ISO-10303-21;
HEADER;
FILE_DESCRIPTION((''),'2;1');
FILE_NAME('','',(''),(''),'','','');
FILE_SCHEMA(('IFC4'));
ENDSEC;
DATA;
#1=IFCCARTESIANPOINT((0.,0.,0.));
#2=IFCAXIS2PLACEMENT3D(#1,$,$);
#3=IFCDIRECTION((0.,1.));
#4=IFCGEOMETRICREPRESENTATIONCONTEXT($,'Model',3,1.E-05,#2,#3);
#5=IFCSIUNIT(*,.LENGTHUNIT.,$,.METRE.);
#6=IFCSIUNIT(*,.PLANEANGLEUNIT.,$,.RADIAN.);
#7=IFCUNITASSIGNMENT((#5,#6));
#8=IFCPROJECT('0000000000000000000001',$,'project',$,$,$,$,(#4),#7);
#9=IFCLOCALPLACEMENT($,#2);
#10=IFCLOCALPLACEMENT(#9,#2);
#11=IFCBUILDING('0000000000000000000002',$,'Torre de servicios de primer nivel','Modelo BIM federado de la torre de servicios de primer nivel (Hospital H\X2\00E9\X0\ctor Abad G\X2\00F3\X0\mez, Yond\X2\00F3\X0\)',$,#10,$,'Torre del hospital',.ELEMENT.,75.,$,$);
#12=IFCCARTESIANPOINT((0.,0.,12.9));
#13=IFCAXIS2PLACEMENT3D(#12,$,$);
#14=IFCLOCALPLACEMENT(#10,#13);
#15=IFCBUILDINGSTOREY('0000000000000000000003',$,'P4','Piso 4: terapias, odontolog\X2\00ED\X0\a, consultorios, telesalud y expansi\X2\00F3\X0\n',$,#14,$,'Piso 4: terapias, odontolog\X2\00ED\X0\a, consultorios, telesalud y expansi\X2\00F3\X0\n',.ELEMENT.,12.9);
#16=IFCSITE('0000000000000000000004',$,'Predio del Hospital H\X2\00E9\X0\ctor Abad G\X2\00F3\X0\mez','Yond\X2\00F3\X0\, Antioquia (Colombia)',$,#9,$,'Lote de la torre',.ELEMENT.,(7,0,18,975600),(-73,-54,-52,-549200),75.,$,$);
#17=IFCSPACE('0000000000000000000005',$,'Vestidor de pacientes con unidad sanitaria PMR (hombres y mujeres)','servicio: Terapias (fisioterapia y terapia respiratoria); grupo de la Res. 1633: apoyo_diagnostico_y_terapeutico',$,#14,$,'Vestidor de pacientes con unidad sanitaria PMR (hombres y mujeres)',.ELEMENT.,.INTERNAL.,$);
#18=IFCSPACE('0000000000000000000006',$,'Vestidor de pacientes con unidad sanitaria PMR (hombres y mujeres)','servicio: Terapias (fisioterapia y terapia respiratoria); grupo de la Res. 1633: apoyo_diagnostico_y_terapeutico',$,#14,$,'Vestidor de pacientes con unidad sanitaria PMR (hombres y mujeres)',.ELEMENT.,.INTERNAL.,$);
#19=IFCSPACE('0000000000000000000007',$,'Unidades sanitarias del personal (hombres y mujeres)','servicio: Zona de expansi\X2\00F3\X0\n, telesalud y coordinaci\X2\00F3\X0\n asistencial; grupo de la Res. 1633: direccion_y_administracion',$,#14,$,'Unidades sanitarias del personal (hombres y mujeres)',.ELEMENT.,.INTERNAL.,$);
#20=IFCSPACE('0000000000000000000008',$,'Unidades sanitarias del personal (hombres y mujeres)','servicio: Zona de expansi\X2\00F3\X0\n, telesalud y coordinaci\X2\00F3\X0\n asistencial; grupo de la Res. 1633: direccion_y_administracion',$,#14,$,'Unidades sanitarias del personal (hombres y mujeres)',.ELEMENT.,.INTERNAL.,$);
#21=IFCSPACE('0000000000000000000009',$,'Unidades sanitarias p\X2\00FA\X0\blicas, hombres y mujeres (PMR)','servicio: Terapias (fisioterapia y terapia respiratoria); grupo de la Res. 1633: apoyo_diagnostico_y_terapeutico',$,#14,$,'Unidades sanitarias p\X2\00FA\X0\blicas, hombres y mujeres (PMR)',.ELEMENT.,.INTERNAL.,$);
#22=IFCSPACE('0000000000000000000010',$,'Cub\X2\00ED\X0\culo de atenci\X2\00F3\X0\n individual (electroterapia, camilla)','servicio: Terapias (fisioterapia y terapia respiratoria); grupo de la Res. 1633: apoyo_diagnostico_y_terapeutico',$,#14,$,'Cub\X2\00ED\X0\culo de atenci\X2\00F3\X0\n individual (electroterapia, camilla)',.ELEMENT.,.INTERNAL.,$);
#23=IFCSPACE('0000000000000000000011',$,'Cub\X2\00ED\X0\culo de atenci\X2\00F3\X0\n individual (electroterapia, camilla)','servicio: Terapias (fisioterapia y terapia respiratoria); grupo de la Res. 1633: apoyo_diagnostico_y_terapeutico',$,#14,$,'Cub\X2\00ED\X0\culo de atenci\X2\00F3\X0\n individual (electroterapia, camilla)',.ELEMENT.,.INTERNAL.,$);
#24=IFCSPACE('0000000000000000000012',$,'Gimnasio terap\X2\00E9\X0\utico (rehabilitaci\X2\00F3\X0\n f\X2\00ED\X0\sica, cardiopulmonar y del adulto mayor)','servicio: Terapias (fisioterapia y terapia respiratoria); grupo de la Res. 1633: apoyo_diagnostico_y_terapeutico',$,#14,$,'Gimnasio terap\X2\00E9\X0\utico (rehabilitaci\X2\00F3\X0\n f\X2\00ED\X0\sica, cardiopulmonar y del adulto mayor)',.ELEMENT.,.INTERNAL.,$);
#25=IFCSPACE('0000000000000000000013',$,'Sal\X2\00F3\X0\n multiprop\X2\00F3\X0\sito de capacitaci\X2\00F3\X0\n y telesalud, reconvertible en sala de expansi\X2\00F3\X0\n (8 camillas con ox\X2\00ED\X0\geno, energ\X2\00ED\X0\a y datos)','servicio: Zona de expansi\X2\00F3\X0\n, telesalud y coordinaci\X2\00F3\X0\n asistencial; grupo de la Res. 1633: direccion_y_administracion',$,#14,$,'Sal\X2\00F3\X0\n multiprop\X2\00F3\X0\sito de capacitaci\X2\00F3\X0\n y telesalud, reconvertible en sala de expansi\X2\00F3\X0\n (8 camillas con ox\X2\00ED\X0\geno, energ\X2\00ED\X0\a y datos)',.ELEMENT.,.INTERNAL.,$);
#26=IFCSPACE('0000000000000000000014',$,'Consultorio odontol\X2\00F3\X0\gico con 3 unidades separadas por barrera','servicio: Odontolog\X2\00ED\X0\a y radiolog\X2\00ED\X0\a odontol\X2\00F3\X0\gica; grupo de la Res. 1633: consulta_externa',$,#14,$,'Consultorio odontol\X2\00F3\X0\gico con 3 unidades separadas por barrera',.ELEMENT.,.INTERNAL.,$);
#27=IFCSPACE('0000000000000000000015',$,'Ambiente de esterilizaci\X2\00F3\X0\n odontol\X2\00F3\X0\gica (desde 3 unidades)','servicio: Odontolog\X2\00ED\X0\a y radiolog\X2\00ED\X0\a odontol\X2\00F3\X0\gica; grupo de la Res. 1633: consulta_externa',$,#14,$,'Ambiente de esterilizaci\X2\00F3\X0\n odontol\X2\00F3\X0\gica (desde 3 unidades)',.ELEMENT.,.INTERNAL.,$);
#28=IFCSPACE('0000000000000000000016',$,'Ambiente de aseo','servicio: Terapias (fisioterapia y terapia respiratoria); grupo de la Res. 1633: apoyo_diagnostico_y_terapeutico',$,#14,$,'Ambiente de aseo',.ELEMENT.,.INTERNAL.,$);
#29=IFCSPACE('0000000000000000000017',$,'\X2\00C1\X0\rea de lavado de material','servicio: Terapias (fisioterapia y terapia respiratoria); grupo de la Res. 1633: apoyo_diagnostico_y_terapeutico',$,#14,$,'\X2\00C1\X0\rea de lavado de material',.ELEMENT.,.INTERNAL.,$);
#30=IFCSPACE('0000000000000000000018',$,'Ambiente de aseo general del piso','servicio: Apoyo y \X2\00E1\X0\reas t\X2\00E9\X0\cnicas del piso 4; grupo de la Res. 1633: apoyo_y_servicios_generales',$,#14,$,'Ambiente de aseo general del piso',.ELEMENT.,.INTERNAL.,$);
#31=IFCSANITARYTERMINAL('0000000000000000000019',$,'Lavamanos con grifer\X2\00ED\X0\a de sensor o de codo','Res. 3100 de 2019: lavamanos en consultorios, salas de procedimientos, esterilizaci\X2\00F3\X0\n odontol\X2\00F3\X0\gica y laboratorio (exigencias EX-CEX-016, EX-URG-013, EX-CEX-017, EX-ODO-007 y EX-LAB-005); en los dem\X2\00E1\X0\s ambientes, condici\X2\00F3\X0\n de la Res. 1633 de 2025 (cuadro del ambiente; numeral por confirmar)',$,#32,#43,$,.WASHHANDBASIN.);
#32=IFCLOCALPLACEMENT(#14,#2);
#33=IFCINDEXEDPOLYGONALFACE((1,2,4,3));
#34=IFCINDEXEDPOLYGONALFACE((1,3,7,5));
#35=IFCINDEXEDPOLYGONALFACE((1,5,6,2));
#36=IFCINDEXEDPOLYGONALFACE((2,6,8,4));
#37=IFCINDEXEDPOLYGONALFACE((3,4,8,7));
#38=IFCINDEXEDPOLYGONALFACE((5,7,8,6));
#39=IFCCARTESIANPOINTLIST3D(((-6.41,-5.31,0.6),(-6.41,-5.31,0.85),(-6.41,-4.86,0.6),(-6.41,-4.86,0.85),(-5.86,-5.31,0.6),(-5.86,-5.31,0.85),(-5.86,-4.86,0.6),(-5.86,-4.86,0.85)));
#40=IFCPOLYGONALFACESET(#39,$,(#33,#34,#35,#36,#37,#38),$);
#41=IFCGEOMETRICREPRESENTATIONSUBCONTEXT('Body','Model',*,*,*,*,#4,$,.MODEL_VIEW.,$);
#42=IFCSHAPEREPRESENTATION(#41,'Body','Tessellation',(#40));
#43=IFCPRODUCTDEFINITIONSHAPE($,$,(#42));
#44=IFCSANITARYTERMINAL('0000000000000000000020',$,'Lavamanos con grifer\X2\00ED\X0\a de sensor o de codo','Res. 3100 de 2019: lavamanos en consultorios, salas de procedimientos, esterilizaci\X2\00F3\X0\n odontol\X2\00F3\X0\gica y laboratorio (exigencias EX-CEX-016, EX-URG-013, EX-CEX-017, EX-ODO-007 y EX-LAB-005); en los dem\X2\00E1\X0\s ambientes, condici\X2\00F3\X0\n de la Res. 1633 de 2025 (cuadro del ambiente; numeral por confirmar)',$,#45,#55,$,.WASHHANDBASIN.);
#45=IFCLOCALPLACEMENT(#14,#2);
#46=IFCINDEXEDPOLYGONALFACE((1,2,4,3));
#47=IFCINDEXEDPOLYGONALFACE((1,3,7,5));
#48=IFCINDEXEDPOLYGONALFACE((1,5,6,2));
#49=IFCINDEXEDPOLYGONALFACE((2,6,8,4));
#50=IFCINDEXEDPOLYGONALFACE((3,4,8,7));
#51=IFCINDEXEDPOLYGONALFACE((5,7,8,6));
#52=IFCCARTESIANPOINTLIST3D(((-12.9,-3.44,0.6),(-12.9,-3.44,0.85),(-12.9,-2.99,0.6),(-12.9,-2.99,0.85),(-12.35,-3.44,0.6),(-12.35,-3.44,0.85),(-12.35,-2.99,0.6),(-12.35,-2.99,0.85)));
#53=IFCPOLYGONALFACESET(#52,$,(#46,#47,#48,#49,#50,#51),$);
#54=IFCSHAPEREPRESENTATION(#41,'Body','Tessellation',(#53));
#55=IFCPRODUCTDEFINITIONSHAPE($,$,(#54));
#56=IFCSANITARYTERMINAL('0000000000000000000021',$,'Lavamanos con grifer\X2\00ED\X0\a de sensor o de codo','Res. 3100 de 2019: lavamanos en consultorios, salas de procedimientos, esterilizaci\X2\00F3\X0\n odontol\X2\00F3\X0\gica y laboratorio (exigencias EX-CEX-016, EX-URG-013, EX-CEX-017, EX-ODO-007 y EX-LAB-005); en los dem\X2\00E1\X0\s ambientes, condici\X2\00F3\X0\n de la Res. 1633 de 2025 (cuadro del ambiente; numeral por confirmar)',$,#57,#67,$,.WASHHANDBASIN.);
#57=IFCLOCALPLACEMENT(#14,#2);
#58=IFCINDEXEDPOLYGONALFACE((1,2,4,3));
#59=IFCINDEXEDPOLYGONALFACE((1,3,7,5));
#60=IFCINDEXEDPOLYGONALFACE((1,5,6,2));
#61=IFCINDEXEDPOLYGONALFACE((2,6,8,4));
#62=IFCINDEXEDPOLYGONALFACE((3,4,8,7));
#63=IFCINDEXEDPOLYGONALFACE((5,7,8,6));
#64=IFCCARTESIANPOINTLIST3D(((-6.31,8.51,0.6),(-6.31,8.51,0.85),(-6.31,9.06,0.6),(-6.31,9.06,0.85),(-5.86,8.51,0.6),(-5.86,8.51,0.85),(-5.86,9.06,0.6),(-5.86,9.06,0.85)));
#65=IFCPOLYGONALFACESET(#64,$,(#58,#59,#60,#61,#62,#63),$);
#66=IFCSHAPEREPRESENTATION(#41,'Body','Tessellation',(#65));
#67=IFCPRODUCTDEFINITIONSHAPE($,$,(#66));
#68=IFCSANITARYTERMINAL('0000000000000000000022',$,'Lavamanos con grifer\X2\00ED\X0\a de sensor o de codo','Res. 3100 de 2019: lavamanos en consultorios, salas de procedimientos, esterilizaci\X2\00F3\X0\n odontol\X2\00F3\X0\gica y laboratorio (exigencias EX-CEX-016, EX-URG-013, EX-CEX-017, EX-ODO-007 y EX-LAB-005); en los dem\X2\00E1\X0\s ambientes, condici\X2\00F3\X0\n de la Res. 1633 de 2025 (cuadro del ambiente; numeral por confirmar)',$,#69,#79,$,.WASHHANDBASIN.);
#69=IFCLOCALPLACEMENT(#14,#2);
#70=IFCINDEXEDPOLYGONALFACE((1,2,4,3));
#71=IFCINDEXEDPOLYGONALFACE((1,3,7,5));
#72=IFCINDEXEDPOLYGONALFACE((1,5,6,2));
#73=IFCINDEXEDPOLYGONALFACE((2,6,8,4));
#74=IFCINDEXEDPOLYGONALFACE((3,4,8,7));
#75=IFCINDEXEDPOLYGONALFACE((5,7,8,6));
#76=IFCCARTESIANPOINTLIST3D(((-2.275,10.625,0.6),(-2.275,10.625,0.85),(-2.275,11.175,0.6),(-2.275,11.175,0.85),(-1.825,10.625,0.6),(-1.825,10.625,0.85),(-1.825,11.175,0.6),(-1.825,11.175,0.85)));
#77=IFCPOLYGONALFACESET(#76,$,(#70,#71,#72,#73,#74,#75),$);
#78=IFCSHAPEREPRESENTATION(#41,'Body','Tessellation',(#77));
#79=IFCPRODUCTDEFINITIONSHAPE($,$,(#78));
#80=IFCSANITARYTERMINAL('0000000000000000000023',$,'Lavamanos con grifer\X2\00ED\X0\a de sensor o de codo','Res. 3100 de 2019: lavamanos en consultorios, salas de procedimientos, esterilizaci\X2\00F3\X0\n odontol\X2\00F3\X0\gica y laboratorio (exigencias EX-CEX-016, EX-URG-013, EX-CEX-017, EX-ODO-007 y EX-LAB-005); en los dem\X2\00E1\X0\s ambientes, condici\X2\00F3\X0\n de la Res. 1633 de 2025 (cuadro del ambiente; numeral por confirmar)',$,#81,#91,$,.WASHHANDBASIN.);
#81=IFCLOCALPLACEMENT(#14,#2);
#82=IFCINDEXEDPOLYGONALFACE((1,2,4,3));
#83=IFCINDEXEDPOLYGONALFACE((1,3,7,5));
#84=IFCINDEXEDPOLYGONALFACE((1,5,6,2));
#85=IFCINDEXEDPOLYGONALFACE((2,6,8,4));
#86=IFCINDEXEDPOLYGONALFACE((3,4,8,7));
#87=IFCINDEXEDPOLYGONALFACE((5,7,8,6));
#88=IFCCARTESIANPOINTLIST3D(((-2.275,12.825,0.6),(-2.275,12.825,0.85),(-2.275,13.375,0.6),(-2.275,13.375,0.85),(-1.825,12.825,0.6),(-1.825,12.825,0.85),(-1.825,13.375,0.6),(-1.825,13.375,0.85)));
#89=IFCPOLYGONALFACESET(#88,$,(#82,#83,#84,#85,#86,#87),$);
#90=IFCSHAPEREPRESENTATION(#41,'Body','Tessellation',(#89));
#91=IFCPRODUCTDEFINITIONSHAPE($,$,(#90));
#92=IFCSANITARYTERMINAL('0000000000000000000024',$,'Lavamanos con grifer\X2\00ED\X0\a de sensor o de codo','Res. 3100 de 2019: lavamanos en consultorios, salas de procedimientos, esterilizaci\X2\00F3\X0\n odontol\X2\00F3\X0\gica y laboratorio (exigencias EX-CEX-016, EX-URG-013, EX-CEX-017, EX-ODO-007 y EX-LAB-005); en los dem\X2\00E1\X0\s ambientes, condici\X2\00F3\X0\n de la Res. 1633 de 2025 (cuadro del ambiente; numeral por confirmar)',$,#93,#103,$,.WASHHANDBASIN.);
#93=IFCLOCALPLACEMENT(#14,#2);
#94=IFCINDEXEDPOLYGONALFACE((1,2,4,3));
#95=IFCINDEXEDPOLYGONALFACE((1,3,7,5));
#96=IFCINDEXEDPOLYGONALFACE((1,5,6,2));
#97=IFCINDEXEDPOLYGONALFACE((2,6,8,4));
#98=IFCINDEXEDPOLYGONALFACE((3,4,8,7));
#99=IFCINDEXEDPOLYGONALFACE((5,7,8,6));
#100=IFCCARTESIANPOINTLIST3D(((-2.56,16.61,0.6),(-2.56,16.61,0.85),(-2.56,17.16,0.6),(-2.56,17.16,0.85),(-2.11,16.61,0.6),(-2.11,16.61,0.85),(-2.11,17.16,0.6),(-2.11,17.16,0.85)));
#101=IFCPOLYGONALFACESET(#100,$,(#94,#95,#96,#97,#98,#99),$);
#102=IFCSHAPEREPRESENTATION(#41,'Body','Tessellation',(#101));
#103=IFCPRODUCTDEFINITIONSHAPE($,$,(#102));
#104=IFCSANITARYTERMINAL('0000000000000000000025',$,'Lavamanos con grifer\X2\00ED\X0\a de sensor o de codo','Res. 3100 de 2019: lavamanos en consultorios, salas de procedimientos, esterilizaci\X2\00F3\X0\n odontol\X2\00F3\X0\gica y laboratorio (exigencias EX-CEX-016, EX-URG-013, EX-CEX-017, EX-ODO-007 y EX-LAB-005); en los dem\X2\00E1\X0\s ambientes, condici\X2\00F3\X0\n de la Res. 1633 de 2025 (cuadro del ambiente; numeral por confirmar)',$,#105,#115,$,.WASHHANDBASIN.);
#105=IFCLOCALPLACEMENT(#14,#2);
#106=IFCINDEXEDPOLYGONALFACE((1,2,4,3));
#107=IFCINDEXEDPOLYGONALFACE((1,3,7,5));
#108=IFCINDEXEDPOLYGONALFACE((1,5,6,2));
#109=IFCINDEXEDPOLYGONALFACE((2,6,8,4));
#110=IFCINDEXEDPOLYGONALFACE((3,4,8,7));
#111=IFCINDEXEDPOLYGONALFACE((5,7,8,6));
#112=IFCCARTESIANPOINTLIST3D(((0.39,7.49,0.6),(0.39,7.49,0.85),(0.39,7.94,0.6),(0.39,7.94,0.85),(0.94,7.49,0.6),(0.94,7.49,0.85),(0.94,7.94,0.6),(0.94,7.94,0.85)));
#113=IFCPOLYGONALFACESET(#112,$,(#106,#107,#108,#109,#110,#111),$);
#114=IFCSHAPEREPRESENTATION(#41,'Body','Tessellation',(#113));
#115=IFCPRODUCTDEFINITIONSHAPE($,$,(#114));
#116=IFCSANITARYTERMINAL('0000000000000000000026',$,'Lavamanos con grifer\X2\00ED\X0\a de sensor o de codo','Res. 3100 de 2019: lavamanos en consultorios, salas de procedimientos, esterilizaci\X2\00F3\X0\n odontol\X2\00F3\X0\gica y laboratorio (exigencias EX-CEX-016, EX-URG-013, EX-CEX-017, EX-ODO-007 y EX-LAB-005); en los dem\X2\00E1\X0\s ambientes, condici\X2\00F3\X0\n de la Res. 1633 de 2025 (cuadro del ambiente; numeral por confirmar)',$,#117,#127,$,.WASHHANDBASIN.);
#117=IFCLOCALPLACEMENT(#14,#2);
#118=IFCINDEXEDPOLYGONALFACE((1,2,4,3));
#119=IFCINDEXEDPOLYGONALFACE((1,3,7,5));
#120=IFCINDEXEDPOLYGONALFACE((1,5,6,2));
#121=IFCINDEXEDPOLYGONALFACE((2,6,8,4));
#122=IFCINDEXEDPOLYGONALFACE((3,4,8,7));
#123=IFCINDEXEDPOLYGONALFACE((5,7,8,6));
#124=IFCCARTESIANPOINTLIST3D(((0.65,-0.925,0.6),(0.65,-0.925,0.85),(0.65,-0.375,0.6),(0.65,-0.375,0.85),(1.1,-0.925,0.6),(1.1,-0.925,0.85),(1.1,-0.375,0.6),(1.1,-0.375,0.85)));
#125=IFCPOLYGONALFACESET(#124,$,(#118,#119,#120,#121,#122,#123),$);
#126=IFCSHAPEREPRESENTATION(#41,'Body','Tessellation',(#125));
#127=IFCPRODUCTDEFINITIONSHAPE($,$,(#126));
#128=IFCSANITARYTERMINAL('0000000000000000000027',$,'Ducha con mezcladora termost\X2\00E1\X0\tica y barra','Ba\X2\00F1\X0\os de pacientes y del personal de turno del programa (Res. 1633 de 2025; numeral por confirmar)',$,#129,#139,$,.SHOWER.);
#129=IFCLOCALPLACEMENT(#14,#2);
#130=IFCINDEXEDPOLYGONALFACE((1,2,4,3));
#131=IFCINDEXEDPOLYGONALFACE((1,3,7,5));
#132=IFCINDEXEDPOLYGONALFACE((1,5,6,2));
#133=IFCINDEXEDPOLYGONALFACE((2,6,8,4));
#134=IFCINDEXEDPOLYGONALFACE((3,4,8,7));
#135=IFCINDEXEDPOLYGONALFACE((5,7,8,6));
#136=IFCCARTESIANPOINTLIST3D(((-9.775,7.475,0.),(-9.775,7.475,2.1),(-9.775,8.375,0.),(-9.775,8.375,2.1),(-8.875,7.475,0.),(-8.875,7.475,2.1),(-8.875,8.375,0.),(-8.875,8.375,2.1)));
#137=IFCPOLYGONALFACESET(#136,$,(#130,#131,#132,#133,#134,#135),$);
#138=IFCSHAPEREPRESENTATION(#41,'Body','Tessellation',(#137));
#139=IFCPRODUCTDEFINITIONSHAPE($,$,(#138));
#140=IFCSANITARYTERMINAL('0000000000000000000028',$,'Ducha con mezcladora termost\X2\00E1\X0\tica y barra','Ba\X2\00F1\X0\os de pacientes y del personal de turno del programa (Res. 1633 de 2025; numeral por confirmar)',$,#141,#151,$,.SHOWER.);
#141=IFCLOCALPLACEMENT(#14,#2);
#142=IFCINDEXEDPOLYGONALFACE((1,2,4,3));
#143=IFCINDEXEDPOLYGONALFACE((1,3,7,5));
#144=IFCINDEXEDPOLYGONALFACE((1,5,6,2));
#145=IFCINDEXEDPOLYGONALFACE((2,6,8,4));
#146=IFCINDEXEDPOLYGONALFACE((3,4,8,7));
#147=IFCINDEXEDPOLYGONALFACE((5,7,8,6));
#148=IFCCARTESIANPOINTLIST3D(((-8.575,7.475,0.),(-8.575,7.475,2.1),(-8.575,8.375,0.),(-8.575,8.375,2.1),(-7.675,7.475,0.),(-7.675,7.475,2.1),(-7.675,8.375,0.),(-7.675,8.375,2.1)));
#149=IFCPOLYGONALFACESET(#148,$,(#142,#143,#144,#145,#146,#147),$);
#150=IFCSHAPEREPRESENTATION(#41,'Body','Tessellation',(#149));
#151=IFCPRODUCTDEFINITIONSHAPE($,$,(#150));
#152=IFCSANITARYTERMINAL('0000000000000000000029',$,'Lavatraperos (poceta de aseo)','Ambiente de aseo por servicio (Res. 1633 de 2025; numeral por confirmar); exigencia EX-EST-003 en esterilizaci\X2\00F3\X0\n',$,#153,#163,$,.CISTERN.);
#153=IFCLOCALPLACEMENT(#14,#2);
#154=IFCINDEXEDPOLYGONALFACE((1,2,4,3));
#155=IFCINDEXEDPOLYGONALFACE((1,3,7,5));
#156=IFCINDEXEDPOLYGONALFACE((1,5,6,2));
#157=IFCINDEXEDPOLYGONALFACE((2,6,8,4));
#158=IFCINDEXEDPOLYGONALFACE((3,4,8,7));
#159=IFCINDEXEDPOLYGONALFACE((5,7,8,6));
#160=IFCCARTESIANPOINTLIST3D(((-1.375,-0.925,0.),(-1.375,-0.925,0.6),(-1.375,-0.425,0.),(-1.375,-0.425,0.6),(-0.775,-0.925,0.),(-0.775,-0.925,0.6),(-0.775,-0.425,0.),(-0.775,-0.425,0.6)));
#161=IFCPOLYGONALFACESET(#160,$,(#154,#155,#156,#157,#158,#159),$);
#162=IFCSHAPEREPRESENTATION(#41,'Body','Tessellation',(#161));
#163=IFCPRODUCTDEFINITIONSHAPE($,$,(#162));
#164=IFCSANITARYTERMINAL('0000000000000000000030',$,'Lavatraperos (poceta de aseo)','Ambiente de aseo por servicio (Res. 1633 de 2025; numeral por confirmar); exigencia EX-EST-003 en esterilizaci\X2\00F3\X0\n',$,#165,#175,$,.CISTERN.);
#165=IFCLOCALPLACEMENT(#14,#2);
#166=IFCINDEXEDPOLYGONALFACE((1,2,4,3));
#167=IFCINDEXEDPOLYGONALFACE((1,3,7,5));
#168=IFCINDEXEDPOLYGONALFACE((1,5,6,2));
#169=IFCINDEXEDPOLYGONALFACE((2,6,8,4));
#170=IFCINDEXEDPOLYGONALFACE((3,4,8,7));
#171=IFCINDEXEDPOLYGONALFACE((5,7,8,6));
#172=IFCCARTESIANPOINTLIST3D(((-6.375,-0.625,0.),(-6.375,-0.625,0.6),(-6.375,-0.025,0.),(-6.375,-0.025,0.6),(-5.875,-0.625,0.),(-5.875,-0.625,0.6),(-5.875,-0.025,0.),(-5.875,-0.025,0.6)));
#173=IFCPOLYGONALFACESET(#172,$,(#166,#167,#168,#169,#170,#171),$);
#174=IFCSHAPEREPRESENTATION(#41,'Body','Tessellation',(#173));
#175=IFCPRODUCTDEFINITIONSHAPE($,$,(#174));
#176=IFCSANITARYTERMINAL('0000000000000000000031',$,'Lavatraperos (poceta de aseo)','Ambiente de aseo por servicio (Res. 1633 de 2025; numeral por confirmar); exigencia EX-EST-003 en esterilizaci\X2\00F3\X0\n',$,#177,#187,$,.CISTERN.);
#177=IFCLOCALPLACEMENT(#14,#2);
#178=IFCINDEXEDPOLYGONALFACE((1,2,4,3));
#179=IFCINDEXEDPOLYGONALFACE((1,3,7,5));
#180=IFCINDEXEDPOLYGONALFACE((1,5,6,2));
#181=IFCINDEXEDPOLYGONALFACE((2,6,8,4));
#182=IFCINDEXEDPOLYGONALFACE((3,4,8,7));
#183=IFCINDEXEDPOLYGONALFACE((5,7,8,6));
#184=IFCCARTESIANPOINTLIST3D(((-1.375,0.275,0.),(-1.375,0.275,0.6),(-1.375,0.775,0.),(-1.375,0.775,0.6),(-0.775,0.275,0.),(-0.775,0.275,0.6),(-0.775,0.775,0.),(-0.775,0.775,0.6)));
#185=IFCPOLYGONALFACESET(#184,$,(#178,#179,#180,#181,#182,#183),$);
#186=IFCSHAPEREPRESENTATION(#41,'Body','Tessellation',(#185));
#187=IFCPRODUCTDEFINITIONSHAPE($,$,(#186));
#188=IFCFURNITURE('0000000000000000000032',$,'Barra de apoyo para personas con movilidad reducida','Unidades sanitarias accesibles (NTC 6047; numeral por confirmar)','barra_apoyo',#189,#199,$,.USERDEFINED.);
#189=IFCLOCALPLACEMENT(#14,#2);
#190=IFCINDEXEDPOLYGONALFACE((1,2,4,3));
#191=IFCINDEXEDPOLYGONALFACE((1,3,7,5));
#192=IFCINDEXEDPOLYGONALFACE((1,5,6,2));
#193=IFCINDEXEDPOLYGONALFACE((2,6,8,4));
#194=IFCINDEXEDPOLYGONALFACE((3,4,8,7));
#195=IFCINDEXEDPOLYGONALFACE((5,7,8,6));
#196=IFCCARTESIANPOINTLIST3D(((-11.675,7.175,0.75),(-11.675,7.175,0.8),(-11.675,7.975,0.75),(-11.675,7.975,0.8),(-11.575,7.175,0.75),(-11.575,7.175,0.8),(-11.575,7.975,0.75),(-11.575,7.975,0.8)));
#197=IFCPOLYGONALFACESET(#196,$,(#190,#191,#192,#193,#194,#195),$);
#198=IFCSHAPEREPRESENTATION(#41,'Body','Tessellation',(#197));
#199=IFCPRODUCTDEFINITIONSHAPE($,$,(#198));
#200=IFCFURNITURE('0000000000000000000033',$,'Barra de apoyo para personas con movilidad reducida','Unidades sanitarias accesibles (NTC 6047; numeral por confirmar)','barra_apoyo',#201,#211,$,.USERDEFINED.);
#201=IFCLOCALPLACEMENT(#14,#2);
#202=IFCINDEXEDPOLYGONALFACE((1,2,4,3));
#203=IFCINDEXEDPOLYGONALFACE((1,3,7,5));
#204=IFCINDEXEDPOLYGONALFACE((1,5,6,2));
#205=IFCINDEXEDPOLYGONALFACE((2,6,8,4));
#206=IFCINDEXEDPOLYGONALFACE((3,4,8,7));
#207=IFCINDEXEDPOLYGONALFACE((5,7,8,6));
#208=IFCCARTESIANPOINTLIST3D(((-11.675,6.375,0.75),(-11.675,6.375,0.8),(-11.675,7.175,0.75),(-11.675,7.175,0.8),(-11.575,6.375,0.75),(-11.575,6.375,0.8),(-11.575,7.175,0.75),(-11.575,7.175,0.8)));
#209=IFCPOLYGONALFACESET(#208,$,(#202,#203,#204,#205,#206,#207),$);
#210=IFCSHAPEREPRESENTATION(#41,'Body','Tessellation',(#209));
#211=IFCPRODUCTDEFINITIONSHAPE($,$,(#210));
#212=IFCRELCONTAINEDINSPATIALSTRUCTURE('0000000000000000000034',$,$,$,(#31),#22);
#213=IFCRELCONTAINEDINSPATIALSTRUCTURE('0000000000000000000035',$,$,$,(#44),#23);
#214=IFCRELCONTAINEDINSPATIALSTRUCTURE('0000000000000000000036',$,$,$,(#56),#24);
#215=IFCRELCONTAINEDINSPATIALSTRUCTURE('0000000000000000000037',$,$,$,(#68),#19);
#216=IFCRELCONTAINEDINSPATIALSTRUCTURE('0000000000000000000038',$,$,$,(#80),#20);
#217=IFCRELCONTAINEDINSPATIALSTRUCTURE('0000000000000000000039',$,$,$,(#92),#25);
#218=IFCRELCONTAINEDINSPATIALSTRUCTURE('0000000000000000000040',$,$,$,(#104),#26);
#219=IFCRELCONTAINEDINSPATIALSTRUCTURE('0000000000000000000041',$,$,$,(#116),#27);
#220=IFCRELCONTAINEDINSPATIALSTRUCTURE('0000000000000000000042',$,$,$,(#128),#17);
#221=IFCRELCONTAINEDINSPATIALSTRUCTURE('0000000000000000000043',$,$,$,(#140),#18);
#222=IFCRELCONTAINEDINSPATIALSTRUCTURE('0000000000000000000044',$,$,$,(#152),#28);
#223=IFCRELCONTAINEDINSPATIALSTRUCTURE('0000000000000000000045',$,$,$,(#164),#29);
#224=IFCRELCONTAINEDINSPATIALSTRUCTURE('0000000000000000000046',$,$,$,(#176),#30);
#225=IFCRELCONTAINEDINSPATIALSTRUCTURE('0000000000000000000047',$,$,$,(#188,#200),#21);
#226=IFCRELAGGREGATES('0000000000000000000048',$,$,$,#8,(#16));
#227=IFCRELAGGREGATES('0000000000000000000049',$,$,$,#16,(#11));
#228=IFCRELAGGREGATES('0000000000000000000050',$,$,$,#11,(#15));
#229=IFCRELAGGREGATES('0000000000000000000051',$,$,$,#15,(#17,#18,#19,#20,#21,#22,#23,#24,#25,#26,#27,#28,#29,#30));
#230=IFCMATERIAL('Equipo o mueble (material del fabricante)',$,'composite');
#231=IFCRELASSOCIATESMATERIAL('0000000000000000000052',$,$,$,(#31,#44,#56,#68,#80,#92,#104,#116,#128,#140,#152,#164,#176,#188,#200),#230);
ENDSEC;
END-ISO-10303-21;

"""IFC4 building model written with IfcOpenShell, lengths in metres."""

from ifc_helpers import new_model, si_unit, direction, frame, origin, place, context, subcontext, project, spatial, rectangle, extrude, material, element, save


model = new_model("IFC4")

# Units and contexts
model_context = context("Model", 3, precision=1e-05, world=origin(), true_north=direction((0.0, 1.0)))
body_context = subcontext(model_context, "Body", "Model", "MODEL_VIEW")
ifc_project = project(units=[si_unit("LENGTHUNIT", "METRE"), si_unit("PLANEANGLEUNIT", "RADIAN")], contexts=[model_context])

# Site, building, storey
site_placement = place(None, origin())
site = spatial("IfcSite", under=ifc_project, at=site_placement, Name="Predio del Hospital Héctor Abad Gómez", Description="Yondó, Antioquia (Colombia)", LongName="Lote de la torre", CompositionType="ELEMENT", RefLatitude=(7, 0, 18, 975600), RefLongitude=(-73, -54, -52, -549200), RefElevation=75.0)
building_placement = place(site_placement, origin())
building = spatial("IfcBuilding", under=site, at=building_placement, Name="Torre de servicios de primer nivel", Description="Modelo BIM federado de la torre de servicios de primer nivel (Hospital Héctor Abad Gómez, Yondó)", LongName="Torre del hospital", CompositionType="ELEMENT", ElevationOfRefHeight=75.0)
placement = place(building_placement, frame((0.0, 0.0, 12.9)))
storey = spatial("IfcBuildingStorey", under=building, at=placement, Name="P4", Description="Piso 4: terapias, odontología, consultorios, telesalud y expansión", LongName="Piso 4: terapias, odontología, consultorios, telesalud y expansión", CompositionType="ELEMENT", Elevation=12.9)

# Shared definitions
ifc_material = material(Name="Equipo o mueble (material del fabricante)", Category="composite")

# Shared definitions
space_1 = spatial("IfcSpace", under=storey, at=placement, Name="Vestidor de pacientes con unidad sanitaria PMR (hombres y mujeres)", Description="servicio: Terapias (fisioterapia y terapia respiratoria); grupo de la Res. 1633: apoyo_diagnostico_y_terapeutico", LongName="Vestidor de pacientes con unidad sanitaria PMR (hombres y mujeres)", CompositionType="ELEMENT", PredefinedType="INTERNAL")

# Shared definitions
space_2 = spatial("IfcSpace", under=storey, at=placement, Name="Vestidor de pacientes con unidad sanitaria PMR (hombres y mujeres)", Description="servicio: Terapias (fisioterapia y terapia respiratoria); grupo de la Res. 1633: apoyo_diagnostico_y_terapeutico", LongName="Vestidor de pacientes con unidad sanitaria PMR (hombres y mujeres)", CompositionType="ELEMENT", PredefinedType="INTERNAL")

# Shared definitions
space_3 = spatial("IfcSpace", under=storey, at=placement, Name="Unidades sanitarias del personal (hombres y mujeres)", Description="servicio: Zona de expansión, telesalud y coordinación asistencial; grupo de la Res. 1633: direccion_y_administracion", LongName="Unidades sanitarias del personal (hombres y mujeres)", CompositionType="ELEMENT", PredefinedType="INTERNAL")

# Shared definitions
space_4 = spatial("IfcSpace", under=storey, at=placement, Name="Unidades sanitarias del personal (hombres y mujeres)", Description="servicio: Zona de expansión, telesalud y coordinación asistencial; grupo de la Res. 1633: direccion_y_administracion", LongName="Unidades sanitarias del personal (hombres y mujeres)", CompositionType="ELEMENT", PredefinedType="INTERNAL")

# Shared definitions
space_5 = spatial("IfcSpace", under=storey, at=placement, Name="Unidades sanitarias públicas, hombres y mujeres (PMR)", Description="servicio: Terapias (fisioterapia y terapia respiratoria); grupo de la Res. 1633: apoyo_diagnostico_y_terapeutico", LongName="Unidades sanitarias públicas, hombres y mujeres (PMR)", CompositionType="ELEMENT", PredefinedType="INTERNAL")

# Shared definitions
space_6 = spatial("IfcSpace", under=storey, at=placement, Name="Cubículo de atención individual (electroterapia, camilla)", Description="servicio: Terapias (fisioterapia y terapia respiratoria); grupo de la Res. 1633: apoyo_diagnostico_y_terapeutico", LongName="Cubículo de atención individual (electroterapia, camilla)", CompositionType="ELEMENT", PredefinedType="INTERNAL")

# Sanitary terminal
element("IfcSanitaryTerminal", 1, at=placement, inside=space_6, material=ifc_material, Name="Lavamanos con grifería de sensor o de codo", Description="Res. 3100 de 2019: lavamanos en consultorios, salas de procedimientos, esterilización odontológica y laboratorio (exigencias EX-CEX-016, EX-URG-013, EX-CEX-017, EX-ODO-007 y EX-LAB-005); en los demás ambientes, condición de la Res. 1633 de 2025 (cuadro del ambiente; numeral por confirmar)", PredefinedType="WASHHANDBASIN", context=body_context, shape_type="SweptSolid", body=[
    extrude(rectangle(XDim=0.55, YDim=0.45), frame((-6.135, -5.085, 0.6), z_axis=(0.0, 0.0, 1.0), x_axis=(-1.0, 0.0, 0.0)), (0.0, 0.0, 1.0), 0.25),
])

# Shared definitions
space_7 = spatial("IfcSpace", under=storey, at=placement, Name="Cubículo de atención individual (electroterapia, camilla)", Description="servicio: Terapias (fisioterapia y terapia respiratoria); grupo de la Res. 1633: apoyo_diagnostico_y_terapeutico", LongName="Cubículo de atención individual (electroterapia, camilla)", CompositionType="ELEMENT", PredefinedType="INTERNAL")

# Sanitary terminal
element("IfcSanitaryTerminal", 2, at=placement, inside=space_7, material=ifc_material, Name="Lavamanos con grifería de sensor o de codo", Description="Res. 3100 de 2019: lavamanos en consultorios, salas de procedimientos, esterilización odontológica y laboratorio (exigencias EX-CEX-016, EX-URG-013, EX-CEX-017, EX-ODO-007 y EX-LAB-005); en los demás ambientes, condición de la Res. 1633 de 2025 (cuadro del ambiente; numeral por confirmar)", PredefinedType="WASHHANDBASIN", context=body_context, shape_type="SweptSolid", body=[
    extrude(rectangle(XDim=0.55, YDim=0.45), frame((-12.625, -3.215, 0.6)), (0.0, 0.0, 1.0), 0.25),
])

# Shared definitions
space_8 = spatial("IfcSpace", under=storey, at=placement, Name="Gimnasio terapéutico (rehabilitación física, cardiopulmonar y del adulto mayor)", Description="servicio: Terapias (fisioterapia y terapia respiratoria); grupo de la Res. 1633: apoyo_diagnostico_y_terapeutico", LongName="Gimnasio terapéutico (rehabilitación física, cardiopulmonar y del adulto mayor)", CompositionType="ELEMENT", PredefinedType="INTERNAL")

# Sanitary terminals
element("IfcSanitaryTerminal", 3, at=placement, inside=space_8, material=ifc_material, Name="Lavamanos con grifería de sensor o de codo", Description="Res. 3100 de 2019: lavamanos en consultorios, salas de procedimientos, esterilización odontológica y laboratorio (exigencias EX-CEX-016, EX-URG-013, EX-CEX-017, EX-ODO-007 y EX-LAB-005); en los demás ambientes, condición de la Res. 1633 de 2025 (cuadro del ambiente; numeral por confirmar)", PredefinedType="WASHHANDBASIN", context=body_context, shape_type="SweptSolid", body=[
    extrude(rectangle(XDim=0.55, YDim=0.45), frame((-6.085, 8.785, 0.6), z_axis=(0.0, 0.0, 1.0), x_axis=(0.0, 1.0, 0.0)), (0.0, 0.0, 1.0), 0.25),
])
element("IfcSanitaryTerminal", 4, at=placement, inside=space_3, material=ifc_material, Name="Lavamanos con grifería de sensor o de codo", Description="Res. 3100 de 2019: lavamanos en consultorios, salas de procedimientos, esterilización odontológica y laboratorio (exigencias EX-CEX-016, EX-URG-013, EX-CEX-017, EX-ODO-007 y EX-LAB-005); en los demás ambientes, condición de la Res. 1633 de 2025 (cuadro del ambiente; numeral por confirmar)", PredefinedType="WASHHANDBASIN", context=body_context, shape_type="SweptSolid", body=[
    extrude(rectangle(XDim=0.55, YDim=0.45), frame((-2.05, 10.9, 0.6), z_axis=(0.0, 0.0, 1.0), x_axis=(0.0, 1.0, 0.0)), (0.0, 0.0, 1.0), 0.25),
])
element("IfcSanitaryTerminal", 5, at=placement, inside=space_4, material=ifc_material, Name="Lavamanos con grifería de sensor o de codo", Description="Res. 3100 de 2019: lavamanos en consultorios, salas de procedimientos, esterilización odontológica y laboratorio (exigencias EX-CEX-016, EX-URG-013, EX-CEX-017, EX-ODO-007 y EX-LAB-005); en los demás ambientes, condición de la Res. 1633 de 2025 (cuadro del ambiente; numeral por confirmar)", PredefinedType="WASHHANDBASIN", context=body_context, shape_type="SweptSolid", body=[
    extrude(rectangle(XDim=0.55, YDim=0.45), frame((-2.05, 13.1, 0.6), z_axis=(0.0, 0.0, 1.0), x_axis=(0.0, 1.0, 0.0)), (0.0, 0.0, 1.0), 0.25),
])

# Shared definitions
space_9 = spatial("IfcSpace", under=storey, at=placement, Name="Salón multipropósito de capacitación y telesalud, reconvertible en sala de expansión (8 camillas con oxígeno, energía y datos)", Description="servicio: Zona de expansión, telesalud y coordinación asistencial; grupo de la Res. 1633: direccion_y_administracion", LongName="Salón multipropósito de capacitación y telesalud, reconvertible en sala de expansión (8 camillas con oxígeno, energía y datos)", CompositionType="ELEMENT", PredefinedType="INTERNAL")

# Sanitary terminal
element("IfcSanitaryTerminal", 6, at=placement, inside=space_9, material=ifc_material, Name="Lavamanos con grifería de sensor o de codo", Description="Res. 3100 de 2019: lavamanos en consultorios, salas de procedimientos, esterilización odontológica y laboratorio (exigencias EX-CEX-016, EX-URG-013, EX-CEX-017, EX-ODO-007 y EX-LAB-005); en los demás ambientes, condición de la Res. 1633 de 2025 (cuadro del ambiente; numeral por confirmar)", PredefinedType="WASHHANDBASIN", context=body_context, shape_type="SweptSolid", body=[
    extrude(rectangle(XDim=0.55, YDim=0.45), frame((-2.335, 16.885, 0.6), z_axis=(0.0, 0.0, 1.0), x_axis=(0.0, 1.0, 0.0)), (0.0, 0.0, 1.0), 0.25),
])

# Shared definitions
space_10 = spatial("IfcSpace", under=storey, at=placement, Name="Consultorio odontológico con 3 unidades separadas por barrera", Description="servicio: Odontología y radiología odontológica; grupo de la Res. 1633: consulta_externa", LongName="Consultorio odontológico con 3 unidades separadas por barrera", CompositionType="ELEMENT", PredefinedType="INTERNAL")

# Sanitary terminal
element("IfcSanitaryTerminal", 7, at=placement, inside=space_10, material=ifc_material, Name="Lavamanos con grifería de sensor o de codo", Description="Res. 3100 de 2019: lavamanos en consultorios, salas de procedimientos, esterilización odontológica y laboratorio (exigencias EX-CEX-016, EX-URG-013, EX-CEX-017, EX-ODO-007 y EX-LAB-005); en los demás ambientes, condición de la Res. 1633 de 2025 (cuadro del ambiente; numeral por confirmar)", PredefinedType="WASHHANDBASIN", context=body_context, shape_type="SweptSolid", body=[
    extrude(rectangle(XDim=0.55, YDim=0.45), frame((0.665, 7.715, 0.6), z_axis=(0.0, 0.0, 1.0), x_axis=(-1.0, 0.0, 0.0)), (0.0, 0.0, 1.0), 0.25),
])

# Shared definitions
space_11 = spatial("IfcSpace", under=storey, at=placement, Name="Ambiente de esterilización odontológica (desde 3 unidades)", Description="servicio: Odontología y radiología odontológica; grupo de la Res. 1633: consulta_externa", LongName="Ambiente de esterilización odontológica (desde 3 unidades)", CompositionType="ELEMENT", PredefinedType="INTERNAL")

# Sanitary terminals
element("IfcSanitaryTerminal", 8, at=placement, inside=space_11, material=ifc_material, Name="Lavamanos con grifería de sensor o de codo", Description="Res. 3100 de 2019: lavamanos en consultorios, salas de procedimientos, esterilización odontológica y laboratorio (exigencias EX-CEX-016, EX-URG-013, EX-CEX-017, EX-ODO-007 y EX-LAB-005); en los demás ambientes, condición de la Res. 1633 de 2025 (cuadro del ambiente; numeral por confirmar)", PredefinedType="WASHHANDBASIN", context=body_context, shape_type="SweptSolid", body=[
    extrude(rectangle(XDim=0.55, YDim=0.45), frame((0.875, -0.65, 0.6), z_axis=(0.0, 0.0, 1.0), x_axis=(0.0, 1.0, 0.0)), (0.0, 0.0, 1.0), 0.25),
])
element("IfcSanitaryTerminal", 9, at=placement, inside=space_1, material=ifc_material, Name="Ducha con mezcladora termostática y barra", Description="Baños de pacientes y del personal de turno del programa (Res. 1633 de 2025; numeral por confirmar)", PredefinedType="SHOWER", context=body_context, shape_type="SweptSolid", body=[
    extrude(rectangle(XDim=0.9, YDim=0.9), frame((-9.325, 7.925, 0.0), z_axis=(0.0, 0.0, 1.0), x_axis=(0.0, 1.0, 0.0)), (0.0, 0.0, 1.0), 2.1),
])
element("IfcSanitaryTerminal", 10, at=placement, inside=space_2, material=ifc_material, Name="Ducha con mezcladora termostática y barra", Description="Baños de pacientes y del personal de turno del programa (Res. 1633 de 2025; numeral por confirmar)", PredefinedType="SHOWER", context=body_context, shape_type="SweptSolid", body=[
    extrude(rectangle(XDim=0.9, YDim=0.9), frame((-8.125, 7.925, 0.0), z_axis=(0.0, 0.0, 1.0), x_axis=(0.0, 1.0, 0.0)), (0.0, 0.0, 1.0), 2.1),
])

# Shared definitions
space_12 = spatial("IfcSpace", under=storey, at=placement, Name="Ambiente de aseo", Description="servicio: Terapias (fisioterapia y terapia respiratoria); grupo de la Res. 1633: apoyo_diagnostico_y_terapeutico", LongName="Ambiente de aseo", CompositionType="ELEMENT", PredefinedType="INTERNAL")

# Sanitary terminal
element("IfcSanitaryTerminal", 11, at=placement, inside=space_12, material=ifc_material, Name="Lavatraperos (poceta de aseo)", Description="Ambiente de aseo por servicio (Res. 1633 de 2025; numeral por confirmar); exigencia EX-EST-003 en esterilización", PredefinedType="CISTERN", context=body_context, shape_type="SweptSolid", body=[
    extrude(rectangle(XDim=0.6, YDim=0.5), frame((-1.075, -0.675, 0.0)), (0.0, 0.0, 1.0), 0.6),
])

# Shared definitions
space_13 = spatial("IfcSpace", under=storey, at=placement, Name="Área de lavado de material", Description="servicio: Terapias (fisioterapia y terapia respiratoria); grupo de la Res. 1633: apoyo_diagnostico_y_terapeutico", LongName="Área de lavado de material", CompositionType="ELEMENT", PredefinedType="INTERNAL")

# Sanitary terminal
element("IfcSanitaryTerminal", 12, at=placement, inside=space_13, material=ifc_material, Name="Lavatraperos (poceta de aseo)", Description="Ambiente de aseo por servicio (Res. 1633 de 2025; numeral por confirmar); exigencia EX-EST-003 en esterilización", PredefinedType="CISTERN", context=body_context, shape_type="SweptSolid", body=[
    extrude(rectangle(XDim=0.6, YDim=0.5), frame((-6.125, -0.325, 0.0), z_axis=(0.0, 0.0, 1.0), x_axis=(0.0, 1.0, 0.0)), (0.0, 0.0, 1.0), 0.6),
])

# Shared definitions
space_14 = spatial("IfcSpace", under=storey, at=placement, Name="Ambiente de aseo general del piso", Description="servicio: Apoyo y áreas técnicas del piso 4; grupo de la Res. 1633: apoyo_y_servicios_generales", LongName="Ambiente de aseo general del piso", CompositionType="ELEMENT", PredefinedType="INTERNAL")

# Sanitary terminal
element("IfcSanitaryTerminal", 13, at=placement, inside=space_14, material=ifc_material, Name="Lavatraperos (poceta de aseo)", Description="Ambiente de aseo por servicio (Res. 1633 de 2025; numeral por confirmar); exigencia EX-EST-003 en esterilización", PredefinedType="CISTERN", context=body_context, shape_type="SweptSolid", body=[
    extrude(rectangle(XDim=0.6, YDim=0.5), frame((-1.075, 0.525, 0.0)), (0.0, 0.0, 1.0), 0.6),
])

# Furniture
element("IfcFurniture", 14, at=placement, inside=space_5, material=ifc_material, Name="Barra de apoyo para personas con movilidad reducida", Description="Unidades sanitarias accesibles (NTC 6047; numeral por confirmar)", ObjectType="barra_apoyo", PredefinedType="USERDEFINED", context=body_context, shape_type="SweptSolid", body=[
    extrude(rectangle(XDim=0.8, YDim=0.1), frame((-11.625, 7.575, 0.75), z_axis=(0.0, 0.0, 1.0), x_axis=(0.0, 1.0, 0.0)), (0.0, 0.0, 1.0), 0.05),
])
element("IfcFurniture", 15, at=placement, inside=space_5, material=ifc_material, Name="Barra de apoyo para personas con movilidad reducida", Description="Unidades sanitarias accesibles (NTC 6047; numeral por confirmar)", ObjectType="barra_apoyo", PredefinedType="USERDEFINED", context=body_context, shape_type="SweptSolid", body=[
    extrude(rectangle(XDim=0.8, YDim=0.1), frame((-11.625, 6.775, 0.75), z_axis=(0.0, 0.0, 1.0), x_axis=(0.0, 1.0, 0.0)), (0.0, 0.0, 1.0), 0.05),
])

save(model, "model.ifc")
